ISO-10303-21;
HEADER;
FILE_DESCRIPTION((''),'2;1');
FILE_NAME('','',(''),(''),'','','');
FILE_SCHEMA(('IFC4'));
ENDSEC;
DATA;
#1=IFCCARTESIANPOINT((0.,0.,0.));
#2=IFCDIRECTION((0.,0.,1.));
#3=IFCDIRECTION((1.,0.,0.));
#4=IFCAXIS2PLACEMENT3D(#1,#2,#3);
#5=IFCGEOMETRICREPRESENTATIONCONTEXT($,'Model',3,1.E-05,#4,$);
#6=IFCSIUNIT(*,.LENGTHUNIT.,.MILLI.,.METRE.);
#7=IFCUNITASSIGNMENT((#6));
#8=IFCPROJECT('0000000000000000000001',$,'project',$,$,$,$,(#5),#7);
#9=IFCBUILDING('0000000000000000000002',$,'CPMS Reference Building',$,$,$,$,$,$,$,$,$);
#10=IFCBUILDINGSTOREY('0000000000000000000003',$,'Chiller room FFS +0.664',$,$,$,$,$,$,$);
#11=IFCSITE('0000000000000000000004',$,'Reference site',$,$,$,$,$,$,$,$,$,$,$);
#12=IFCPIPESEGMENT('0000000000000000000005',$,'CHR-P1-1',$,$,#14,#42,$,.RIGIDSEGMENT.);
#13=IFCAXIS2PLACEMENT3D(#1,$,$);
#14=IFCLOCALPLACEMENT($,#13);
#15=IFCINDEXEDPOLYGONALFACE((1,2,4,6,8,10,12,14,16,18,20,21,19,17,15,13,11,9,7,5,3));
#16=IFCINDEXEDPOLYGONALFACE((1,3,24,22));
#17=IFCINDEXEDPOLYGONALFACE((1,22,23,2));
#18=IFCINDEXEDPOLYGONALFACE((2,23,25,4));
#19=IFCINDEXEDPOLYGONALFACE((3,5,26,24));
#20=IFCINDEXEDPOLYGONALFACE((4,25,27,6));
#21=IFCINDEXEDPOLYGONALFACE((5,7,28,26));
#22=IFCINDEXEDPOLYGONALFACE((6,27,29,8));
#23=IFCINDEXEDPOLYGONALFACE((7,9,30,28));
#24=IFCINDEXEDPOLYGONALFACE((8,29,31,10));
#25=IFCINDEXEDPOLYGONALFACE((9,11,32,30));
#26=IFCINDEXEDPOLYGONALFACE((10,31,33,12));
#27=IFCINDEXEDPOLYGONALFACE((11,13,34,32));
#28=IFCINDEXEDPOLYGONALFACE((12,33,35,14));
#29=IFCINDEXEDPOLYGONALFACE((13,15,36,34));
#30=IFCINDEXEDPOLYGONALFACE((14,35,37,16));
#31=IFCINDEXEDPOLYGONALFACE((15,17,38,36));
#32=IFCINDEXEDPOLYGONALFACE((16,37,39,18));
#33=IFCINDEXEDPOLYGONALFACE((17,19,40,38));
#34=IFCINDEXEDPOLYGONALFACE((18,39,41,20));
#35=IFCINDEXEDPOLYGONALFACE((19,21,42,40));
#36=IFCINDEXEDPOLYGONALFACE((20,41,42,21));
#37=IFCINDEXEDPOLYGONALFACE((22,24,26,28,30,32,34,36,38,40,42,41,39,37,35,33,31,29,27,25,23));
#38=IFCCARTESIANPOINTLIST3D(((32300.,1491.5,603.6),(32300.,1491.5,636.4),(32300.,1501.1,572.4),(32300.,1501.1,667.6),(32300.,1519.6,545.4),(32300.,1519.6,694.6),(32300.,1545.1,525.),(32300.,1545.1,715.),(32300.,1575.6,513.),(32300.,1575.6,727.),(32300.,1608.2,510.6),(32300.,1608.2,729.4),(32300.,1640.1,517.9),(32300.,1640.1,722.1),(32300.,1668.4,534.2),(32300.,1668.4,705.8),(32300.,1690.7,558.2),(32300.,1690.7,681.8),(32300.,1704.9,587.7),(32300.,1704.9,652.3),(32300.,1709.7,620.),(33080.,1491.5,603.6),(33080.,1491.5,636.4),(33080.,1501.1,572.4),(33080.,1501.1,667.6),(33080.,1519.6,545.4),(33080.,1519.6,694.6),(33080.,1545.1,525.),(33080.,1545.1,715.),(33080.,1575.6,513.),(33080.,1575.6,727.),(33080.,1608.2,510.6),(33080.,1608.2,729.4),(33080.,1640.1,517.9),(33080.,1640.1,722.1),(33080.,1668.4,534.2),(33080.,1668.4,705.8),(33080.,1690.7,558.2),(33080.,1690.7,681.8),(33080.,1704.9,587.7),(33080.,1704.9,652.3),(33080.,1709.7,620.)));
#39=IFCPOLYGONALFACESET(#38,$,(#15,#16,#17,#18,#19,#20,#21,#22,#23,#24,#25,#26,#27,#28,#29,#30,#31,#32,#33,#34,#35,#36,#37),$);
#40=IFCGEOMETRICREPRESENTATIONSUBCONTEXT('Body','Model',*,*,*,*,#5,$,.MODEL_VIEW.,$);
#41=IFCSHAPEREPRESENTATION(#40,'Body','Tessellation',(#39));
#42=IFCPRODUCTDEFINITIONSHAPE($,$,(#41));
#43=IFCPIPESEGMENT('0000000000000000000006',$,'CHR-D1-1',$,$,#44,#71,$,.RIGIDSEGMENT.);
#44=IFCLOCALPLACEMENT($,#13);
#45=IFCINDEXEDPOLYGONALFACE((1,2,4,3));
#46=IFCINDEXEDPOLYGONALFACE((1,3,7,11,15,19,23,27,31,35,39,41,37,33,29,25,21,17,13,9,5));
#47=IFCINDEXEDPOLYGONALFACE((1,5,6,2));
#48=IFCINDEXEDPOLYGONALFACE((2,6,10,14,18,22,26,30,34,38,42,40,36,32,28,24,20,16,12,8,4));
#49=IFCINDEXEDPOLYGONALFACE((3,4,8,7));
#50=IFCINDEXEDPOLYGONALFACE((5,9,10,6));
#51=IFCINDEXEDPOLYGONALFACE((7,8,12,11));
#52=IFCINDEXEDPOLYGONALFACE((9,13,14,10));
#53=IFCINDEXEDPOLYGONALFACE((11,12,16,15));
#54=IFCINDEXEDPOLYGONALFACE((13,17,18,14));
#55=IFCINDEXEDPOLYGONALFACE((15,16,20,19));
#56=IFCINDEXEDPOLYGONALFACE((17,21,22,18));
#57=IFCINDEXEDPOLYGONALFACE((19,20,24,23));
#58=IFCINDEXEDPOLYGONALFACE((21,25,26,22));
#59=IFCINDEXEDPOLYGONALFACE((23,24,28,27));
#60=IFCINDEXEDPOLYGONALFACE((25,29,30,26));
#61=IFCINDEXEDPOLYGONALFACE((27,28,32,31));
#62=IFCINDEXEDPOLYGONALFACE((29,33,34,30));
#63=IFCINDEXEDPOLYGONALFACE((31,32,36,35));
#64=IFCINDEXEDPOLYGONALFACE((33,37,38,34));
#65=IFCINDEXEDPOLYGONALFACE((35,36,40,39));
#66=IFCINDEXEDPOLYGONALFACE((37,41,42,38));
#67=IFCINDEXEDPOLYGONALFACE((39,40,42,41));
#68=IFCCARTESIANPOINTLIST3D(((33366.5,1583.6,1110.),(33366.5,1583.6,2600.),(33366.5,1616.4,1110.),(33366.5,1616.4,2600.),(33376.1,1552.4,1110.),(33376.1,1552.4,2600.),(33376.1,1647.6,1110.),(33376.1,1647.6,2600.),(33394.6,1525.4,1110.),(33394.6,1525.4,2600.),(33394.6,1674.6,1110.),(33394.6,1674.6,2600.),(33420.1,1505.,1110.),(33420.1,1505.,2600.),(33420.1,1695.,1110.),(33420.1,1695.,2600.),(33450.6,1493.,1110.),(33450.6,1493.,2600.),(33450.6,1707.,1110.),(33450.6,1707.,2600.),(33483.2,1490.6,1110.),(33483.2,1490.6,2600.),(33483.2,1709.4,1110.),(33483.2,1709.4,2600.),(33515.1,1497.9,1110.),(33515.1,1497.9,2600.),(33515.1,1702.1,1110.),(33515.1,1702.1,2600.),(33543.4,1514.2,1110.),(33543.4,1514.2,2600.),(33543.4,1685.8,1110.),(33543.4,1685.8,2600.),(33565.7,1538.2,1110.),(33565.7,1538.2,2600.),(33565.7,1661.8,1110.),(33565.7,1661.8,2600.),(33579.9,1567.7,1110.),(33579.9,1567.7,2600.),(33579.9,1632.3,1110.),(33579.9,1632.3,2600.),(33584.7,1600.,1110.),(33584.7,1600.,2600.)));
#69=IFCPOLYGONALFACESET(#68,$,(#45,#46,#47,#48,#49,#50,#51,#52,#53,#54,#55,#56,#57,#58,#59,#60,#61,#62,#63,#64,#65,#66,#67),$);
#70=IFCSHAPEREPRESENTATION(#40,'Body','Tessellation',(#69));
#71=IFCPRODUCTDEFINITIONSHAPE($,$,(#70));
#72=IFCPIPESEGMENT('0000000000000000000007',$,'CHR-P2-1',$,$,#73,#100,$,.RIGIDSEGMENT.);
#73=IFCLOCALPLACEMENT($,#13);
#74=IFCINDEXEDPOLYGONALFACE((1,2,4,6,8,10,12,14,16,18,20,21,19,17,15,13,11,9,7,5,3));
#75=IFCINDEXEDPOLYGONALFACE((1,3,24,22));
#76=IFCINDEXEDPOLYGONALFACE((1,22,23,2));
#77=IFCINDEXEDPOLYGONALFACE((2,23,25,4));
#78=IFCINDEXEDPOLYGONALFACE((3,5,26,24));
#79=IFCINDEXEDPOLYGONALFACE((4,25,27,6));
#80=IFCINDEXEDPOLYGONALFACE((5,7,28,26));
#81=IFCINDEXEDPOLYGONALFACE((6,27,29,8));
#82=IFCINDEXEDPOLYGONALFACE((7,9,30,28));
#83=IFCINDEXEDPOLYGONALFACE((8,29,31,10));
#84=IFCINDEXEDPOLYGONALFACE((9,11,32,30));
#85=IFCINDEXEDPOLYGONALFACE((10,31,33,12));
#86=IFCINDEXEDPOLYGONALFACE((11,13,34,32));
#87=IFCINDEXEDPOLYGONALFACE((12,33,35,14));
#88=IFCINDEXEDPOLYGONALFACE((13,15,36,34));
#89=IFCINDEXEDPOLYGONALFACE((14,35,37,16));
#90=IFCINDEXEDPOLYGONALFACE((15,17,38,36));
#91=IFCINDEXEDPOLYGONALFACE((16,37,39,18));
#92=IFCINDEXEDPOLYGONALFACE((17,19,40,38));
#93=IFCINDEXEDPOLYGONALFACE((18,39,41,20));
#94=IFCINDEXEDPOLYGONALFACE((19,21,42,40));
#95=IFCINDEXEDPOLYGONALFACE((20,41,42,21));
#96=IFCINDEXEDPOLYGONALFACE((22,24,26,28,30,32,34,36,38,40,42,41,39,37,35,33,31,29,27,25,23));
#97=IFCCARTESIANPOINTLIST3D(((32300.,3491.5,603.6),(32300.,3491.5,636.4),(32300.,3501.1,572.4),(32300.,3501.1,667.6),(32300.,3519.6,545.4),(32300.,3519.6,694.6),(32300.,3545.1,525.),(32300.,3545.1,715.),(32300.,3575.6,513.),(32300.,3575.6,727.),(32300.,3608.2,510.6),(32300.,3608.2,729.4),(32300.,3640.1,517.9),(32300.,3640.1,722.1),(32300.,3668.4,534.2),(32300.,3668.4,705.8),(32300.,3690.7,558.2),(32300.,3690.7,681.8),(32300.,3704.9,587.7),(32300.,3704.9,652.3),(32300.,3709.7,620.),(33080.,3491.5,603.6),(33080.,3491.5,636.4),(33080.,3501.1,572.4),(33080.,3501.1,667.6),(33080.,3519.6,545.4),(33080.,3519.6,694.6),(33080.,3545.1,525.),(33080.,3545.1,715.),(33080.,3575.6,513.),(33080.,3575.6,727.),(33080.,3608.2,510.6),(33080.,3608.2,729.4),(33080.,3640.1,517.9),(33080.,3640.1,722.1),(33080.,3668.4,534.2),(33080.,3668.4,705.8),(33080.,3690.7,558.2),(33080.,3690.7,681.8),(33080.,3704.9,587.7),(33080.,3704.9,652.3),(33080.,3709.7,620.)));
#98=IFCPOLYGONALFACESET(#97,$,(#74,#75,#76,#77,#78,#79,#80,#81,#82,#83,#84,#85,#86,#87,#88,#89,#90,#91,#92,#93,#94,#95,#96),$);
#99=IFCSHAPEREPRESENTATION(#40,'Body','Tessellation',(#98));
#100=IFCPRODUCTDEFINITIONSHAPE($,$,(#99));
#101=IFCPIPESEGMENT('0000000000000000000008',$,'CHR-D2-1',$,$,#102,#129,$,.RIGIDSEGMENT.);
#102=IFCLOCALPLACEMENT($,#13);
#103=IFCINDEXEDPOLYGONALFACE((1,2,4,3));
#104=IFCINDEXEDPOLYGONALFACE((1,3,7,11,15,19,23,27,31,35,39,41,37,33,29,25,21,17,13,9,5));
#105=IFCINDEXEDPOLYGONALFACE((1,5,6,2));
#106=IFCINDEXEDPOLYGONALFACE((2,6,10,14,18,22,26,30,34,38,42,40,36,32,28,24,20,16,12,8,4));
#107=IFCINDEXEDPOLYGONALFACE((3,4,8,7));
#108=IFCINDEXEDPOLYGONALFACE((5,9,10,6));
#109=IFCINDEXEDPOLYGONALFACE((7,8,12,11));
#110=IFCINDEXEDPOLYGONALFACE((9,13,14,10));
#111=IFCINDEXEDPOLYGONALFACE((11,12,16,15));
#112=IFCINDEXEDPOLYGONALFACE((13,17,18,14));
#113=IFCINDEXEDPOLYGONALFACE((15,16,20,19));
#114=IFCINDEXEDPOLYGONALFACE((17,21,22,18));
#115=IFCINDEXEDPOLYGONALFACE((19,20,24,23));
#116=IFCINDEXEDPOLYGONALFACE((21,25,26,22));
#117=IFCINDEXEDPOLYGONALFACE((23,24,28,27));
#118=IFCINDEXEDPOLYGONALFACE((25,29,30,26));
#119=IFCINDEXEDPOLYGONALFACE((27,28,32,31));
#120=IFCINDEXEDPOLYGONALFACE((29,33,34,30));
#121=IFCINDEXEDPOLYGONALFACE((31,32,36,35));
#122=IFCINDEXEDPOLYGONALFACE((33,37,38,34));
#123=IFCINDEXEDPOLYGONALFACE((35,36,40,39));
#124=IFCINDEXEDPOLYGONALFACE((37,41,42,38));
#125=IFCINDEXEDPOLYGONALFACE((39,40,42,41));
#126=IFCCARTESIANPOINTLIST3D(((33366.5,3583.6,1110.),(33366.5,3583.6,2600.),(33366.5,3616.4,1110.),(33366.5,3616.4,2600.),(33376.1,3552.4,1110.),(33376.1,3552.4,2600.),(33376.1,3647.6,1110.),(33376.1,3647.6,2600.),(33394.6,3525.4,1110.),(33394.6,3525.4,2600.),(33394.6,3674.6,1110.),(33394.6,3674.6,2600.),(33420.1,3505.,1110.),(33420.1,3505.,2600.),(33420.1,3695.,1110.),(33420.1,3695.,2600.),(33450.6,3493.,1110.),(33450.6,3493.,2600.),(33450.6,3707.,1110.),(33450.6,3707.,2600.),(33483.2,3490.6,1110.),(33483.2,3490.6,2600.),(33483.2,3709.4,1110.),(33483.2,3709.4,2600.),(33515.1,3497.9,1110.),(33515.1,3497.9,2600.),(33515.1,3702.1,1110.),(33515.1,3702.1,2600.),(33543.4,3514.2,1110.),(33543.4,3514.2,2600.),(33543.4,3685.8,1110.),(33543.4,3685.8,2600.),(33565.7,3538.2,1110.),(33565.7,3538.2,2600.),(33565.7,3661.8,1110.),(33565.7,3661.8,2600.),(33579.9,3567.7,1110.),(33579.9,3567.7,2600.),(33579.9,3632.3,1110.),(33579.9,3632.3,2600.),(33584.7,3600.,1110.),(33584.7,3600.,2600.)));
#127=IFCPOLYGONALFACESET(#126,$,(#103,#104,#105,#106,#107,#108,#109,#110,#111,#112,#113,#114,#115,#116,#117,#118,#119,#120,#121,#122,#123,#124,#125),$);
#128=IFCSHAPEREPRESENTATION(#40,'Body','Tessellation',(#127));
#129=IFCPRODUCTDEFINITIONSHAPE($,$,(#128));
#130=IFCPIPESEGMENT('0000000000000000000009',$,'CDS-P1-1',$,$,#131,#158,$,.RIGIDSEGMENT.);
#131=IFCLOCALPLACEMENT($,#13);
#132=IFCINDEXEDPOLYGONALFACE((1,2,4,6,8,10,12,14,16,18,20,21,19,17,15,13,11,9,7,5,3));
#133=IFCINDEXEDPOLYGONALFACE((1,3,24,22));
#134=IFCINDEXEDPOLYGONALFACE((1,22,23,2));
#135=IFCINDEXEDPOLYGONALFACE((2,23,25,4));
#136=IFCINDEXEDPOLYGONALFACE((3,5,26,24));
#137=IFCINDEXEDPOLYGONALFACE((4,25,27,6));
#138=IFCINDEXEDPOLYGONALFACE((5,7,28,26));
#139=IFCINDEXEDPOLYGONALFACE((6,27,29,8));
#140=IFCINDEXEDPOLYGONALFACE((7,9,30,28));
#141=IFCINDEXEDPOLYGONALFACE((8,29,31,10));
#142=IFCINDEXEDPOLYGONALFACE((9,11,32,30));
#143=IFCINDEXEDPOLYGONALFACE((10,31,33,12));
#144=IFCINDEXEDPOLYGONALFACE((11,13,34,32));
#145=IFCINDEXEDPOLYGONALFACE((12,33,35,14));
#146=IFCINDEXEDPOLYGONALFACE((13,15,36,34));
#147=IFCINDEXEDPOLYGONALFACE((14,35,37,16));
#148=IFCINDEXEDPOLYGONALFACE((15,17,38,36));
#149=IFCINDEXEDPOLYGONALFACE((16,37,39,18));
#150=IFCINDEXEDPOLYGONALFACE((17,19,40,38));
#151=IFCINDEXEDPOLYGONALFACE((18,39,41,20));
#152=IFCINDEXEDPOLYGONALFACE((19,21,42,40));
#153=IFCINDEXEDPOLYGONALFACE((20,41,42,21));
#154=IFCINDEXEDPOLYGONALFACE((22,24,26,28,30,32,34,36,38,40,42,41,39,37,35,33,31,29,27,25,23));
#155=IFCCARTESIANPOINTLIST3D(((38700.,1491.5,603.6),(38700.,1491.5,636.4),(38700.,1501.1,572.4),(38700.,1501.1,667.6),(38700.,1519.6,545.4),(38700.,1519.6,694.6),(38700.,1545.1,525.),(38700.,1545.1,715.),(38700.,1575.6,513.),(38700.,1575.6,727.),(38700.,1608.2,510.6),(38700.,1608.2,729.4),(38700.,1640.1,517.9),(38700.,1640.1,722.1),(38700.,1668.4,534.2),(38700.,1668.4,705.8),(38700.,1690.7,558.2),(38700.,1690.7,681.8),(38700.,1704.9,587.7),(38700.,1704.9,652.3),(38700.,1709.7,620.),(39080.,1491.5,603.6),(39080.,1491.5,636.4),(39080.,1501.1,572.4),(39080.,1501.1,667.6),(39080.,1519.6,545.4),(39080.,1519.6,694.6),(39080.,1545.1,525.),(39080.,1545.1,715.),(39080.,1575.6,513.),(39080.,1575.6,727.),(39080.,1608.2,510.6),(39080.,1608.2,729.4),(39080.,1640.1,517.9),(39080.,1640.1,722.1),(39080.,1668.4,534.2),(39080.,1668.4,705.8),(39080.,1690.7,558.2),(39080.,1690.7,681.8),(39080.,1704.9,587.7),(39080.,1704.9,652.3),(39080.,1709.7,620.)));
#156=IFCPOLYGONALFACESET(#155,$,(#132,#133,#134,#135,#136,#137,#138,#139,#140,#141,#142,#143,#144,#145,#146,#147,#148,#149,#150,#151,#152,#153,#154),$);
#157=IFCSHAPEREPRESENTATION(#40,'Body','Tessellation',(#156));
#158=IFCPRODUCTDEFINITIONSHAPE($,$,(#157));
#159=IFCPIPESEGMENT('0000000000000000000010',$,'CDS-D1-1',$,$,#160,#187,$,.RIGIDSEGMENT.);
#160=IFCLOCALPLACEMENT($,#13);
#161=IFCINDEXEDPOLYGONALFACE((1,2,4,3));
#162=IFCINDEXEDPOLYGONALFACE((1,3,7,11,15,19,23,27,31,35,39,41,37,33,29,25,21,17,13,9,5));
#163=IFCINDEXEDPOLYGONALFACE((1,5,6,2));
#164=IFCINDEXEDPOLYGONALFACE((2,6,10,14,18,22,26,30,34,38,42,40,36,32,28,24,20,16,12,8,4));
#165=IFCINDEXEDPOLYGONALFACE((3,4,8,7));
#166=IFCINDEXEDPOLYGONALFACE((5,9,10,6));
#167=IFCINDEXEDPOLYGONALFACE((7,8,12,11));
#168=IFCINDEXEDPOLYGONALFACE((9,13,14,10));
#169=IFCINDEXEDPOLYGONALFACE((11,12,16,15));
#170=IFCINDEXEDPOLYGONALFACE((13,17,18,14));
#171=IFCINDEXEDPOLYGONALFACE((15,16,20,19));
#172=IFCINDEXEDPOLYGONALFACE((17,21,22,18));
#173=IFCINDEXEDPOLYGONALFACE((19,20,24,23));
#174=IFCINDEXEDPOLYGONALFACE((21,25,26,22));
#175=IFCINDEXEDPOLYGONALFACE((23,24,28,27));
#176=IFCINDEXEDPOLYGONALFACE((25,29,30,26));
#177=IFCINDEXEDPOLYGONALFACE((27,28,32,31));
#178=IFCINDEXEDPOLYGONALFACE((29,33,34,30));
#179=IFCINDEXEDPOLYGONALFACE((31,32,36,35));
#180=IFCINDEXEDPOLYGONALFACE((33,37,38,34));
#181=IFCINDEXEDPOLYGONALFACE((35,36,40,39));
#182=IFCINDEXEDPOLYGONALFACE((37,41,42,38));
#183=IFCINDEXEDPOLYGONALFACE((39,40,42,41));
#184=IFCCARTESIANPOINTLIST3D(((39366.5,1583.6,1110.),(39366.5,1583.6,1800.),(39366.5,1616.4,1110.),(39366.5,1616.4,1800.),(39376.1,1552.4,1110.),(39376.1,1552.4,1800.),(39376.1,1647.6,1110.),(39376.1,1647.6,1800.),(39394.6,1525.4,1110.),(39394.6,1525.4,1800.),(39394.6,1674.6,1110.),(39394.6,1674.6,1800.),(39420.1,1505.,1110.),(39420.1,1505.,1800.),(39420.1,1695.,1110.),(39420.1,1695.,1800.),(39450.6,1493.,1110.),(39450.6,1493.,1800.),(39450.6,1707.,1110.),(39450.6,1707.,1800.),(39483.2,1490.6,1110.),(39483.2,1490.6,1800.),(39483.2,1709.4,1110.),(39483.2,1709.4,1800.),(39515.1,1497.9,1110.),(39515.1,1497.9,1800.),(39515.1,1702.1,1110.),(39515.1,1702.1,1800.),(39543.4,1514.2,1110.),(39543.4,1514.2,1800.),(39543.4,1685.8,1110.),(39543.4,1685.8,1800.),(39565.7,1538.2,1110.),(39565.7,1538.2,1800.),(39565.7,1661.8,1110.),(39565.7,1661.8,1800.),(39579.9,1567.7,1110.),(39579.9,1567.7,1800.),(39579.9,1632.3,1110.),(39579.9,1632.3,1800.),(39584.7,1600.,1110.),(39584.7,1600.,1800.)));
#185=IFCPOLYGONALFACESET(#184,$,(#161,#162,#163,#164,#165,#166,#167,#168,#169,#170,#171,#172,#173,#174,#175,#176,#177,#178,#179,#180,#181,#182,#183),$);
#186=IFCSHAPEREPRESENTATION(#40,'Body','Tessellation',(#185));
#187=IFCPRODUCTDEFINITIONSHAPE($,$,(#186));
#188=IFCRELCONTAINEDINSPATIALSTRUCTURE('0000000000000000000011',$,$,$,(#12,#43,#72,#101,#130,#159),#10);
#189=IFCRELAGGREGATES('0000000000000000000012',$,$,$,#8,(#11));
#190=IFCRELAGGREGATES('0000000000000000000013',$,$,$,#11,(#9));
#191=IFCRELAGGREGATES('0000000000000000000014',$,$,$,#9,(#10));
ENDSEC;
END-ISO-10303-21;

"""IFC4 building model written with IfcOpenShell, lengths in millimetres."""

from ifc_helpers import new_model, si_unit, frame, origin_with_axes, origin_2d, place, context, subcontext, project, spatial, circle_curve, outline, extrude, element, save


model = new_model("IFC4")

# Units and contexts
model_context = context("Model", 3, precision=1e-05, world=origin_with_axes())
body_context = subcontext(model_context, "Body", "Model", "MODEL_VIEW")
ifc_project = project(units=[si_unit("LENGTHUNIT", "METRE", prefix="MILLI")], contexts=[model_context])

# Site, building, storey
site = spatial("IfcSite", under=ifc_project, Name="Reference site")
building = spatial("IfcBuilding", under=site, Name="CPMS Reference Building")
storey = spatial("IfcBuildingStorey", under=building, Name="Chiller room FFS +0.664")

# Pipe segments
pipe_segment_1_placement = place(None, origin_with_axes())
element("IfcPipeSegment", 1, at=pipe_segment_1_placement, inside=storey, Name="CHR-P1-1", PredefinedType="RIGIDSEGMENT", context=body_context, shape_type="SweptSolid", body=[
    extrude(outline(circle_curve(origin_2d(), 109.7)), frame((32300.0, 1600.0, 620.0), z_axis=(1.0, 0.0, 0.0), x_axis=(0.0, 1.0, 0.0)), (0.0, 0.0, 1.0), 780.0),
])
pipe_segment_2_placement = place(None, origin_with_axes())
element("IfcPipeSegment", 2, at=pipe_segment_2_placement, inside=storey, Name="CHR-D1-1", PredefinedType="RIGIDSEGMENT", context=body_context, shape_type="SweptSolid", body=[
    extrude(outline(circle_curve(origin_2d(), 109.7)), frame((33475.0, 1600.0, 1110.0), z_axis=(0.0, 0.0, 1.0), x_axis=(1.0, 0.0, 0.0)), (0.0, 0.0, 1.0), 1490.0),
])
pipe_segment_3_placement = place(None, origin_with_axes())
element("IfcPipeSegment", 3, at=pipe_segment_3_placement, inside=storey, Name="CHR-P2-1", PredefinedType="RIGIDSEGMENT", context=body_context, shape_type="SweptSolid", body=[
    extrude(outline(circle_curve(origin_2d(), 109.7)), frame((32300.0, 3600.0, 620.0), z_axis=(1.0, 0.0, 0.0), x_axis=(0.0, 1.0, 0.0)), (0.0, 0.0, 1.0), 780.0),
])
pipe_segment_4_placement = place(None, origin_with_axes())
element("IfcPipeSegment", 4, at=pipe_segment_4_placement, inside=storey, Name="CHR-D2-1", PredefinedType="RIGIDSEGMENT", context=body_context, shape_type="SweptSolid", body=[
    extrude(outline(circle_curve(origin_2d(), 109.7)), frame((33475.0, 3600.0, 1110.0), z_axis=(0.0, 0.0, 1.0), x_axis=(1.0, 0.0, 0.0)), (0.0, 0.0, 1.0), 1490.0),
])
pipe_segment_5_placement = place(None, origin_with_axes())
element("IfcPipeSegment", 5, at=pipe_segment_5_placement, inside=storey, Name="CDS-P1-1", PredefinedType="RIGIDSEGMENT", context=body_context, shape_type="SweptSolid", body=[
    extrude(outline(circle_curve(origin_2d(), 109.7)), frame((38700.0, 1600.0, 620.0), z_axis=(1.0, 0.0, 0.0), x_axis=(0.0, 1.0, 0.0)), (0.0, 0.0, 1.0), 380.0),
])
pipe_segment_6_placement = place(None, origin_with_axes())
element("IfcPipeSegment", 6, at=pipe_segment_6_placement, inside=storey, Name="CDS-D1-1", PredefinedType="RIGIDSEGMENT", context=body_context, shape_type="SweptSolid", body=[
    extrude(outline(circle_curve(origin_2d(), 109.7)), frame((39475.0, 1600.0, 1110.0), z_axis=(0.0, 0.0, 1.0), x_axis=(1.0, 0.0, 0.0)), (0.0, 0.0, 1.0), 690.0),
])

save(model, "model.ifc")
